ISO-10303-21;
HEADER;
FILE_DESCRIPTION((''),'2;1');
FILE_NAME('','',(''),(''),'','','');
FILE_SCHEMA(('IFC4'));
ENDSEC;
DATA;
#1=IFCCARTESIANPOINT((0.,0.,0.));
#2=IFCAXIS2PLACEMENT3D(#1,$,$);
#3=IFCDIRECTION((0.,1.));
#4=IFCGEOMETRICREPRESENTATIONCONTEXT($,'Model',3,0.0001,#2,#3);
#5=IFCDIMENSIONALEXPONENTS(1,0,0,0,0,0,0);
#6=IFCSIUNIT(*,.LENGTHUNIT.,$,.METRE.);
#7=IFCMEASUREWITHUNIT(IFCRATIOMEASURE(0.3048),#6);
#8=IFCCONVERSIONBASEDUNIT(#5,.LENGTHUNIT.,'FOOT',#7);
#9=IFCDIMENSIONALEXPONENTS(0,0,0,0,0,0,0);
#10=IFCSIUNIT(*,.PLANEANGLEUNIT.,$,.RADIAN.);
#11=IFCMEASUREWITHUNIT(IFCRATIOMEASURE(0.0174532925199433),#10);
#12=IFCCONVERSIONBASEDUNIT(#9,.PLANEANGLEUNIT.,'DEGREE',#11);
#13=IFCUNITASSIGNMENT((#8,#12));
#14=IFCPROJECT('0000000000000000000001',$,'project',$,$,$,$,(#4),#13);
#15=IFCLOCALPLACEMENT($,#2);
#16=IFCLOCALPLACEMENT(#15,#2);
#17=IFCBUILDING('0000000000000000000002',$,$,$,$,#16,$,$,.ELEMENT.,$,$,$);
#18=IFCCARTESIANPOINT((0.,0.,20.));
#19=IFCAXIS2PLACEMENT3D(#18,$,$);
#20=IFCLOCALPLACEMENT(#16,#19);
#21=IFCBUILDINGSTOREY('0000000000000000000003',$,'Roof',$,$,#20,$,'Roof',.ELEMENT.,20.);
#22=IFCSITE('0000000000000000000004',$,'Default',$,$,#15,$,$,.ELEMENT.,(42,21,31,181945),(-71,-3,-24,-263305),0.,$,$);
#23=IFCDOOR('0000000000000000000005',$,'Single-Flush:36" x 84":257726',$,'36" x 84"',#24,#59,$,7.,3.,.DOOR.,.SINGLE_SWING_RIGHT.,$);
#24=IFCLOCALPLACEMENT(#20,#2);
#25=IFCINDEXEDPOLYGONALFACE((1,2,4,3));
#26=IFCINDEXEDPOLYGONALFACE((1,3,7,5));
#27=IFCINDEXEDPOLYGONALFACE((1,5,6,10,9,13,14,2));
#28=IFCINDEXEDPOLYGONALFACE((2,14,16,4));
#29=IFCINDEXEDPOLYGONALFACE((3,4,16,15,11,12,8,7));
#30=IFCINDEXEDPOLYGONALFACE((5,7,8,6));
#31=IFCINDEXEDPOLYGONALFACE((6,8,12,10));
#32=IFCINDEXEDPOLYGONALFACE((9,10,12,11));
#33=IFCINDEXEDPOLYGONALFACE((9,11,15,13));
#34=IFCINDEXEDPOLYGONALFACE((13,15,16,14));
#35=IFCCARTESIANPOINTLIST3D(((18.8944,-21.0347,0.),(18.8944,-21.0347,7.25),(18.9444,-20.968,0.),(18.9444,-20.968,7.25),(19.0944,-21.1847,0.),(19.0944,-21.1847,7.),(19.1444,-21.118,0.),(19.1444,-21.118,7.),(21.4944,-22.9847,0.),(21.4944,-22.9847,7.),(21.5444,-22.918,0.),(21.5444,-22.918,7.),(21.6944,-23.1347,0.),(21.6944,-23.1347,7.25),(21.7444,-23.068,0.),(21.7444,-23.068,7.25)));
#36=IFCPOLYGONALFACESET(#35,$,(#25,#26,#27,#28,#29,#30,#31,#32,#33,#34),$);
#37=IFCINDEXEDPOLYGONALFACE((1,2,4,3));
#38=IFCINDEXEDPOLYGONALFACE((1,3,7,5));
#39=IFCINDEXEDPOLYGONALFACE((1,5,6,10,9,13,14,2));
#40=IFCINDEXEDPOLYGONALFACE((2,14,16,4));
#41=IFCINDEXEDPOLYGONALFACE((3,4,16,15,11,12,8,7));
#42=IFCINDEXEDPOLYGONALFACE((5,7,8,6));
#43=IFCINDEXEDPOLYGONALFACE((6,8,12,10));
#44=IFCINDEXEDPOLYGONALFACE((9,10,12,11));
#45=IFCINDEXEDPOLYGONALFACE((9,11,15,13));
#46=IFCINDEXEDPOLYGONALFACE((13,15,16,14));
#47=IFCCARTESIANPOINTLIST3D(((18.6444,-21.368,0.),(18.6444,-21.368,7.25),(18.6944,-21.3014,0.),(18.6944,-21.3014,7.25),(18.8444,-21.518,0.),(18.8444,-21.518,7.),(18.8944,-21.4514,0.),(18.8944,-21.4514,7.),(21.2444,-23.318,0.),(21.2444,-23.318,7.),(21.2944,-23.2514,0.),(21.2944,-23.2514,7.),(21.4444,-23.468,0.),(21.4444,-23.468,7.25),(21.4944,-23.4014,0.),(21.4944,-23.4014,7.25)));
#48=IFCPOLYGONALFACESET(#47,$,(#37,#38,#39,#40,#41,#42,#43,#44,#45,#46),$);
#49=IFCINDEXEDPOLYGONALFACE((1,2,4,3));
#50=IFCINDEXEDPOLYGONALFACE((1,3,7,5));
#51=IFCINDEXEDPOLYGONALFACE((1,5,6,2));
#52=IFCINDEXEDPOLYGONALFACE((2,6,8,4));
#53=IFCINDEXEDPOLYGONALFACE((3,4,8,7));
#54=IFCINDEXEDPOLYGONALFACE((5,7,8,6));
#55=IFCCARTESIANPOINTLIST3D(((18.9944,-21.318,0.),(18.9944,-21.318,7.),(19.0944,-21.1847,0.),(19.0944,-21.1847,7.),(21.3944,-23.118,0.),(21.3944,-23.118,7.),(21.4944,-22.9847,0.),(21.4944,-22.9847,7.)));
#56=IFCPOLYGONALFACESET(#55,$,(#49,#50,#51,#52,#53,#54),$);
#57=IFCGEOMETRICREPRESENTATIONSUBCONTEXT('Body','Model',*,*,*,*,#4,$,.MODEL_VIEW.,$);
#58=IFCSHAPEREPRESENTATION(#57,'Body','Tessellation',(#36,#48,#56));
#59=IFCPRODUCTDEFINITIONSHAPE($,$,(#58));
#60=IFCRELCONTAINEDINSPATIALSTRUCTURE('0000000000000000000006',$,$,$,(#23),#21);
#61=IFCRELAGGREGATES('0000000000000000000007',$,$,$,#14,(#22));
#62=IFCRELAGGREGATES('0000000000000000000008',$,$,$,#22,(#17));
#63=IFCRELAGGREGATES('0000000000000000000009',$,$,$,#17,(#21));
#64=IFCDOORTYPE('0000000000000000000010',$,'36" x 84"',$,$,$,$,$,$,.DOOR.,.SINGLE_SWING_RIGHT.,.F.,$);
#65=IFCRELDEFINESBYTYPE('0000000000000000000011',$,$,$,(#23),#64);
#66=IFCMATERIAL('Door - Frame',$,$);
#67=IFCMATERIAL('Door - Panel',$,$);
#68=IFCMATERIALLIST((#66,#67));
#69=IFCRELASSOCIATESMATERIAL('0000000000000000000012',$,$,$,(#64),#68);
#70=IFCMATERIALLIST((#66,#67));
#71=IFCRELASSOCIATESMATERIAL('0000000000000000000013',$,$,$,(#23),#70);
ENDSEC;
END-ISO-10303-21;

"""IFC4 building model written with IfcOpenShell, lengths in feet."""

from ifc_helpers import new_model, entity, si_unit, converted_unit, direction, frame, frame_2d, origin, place, context, subcontext, project, spatial, polyline, rectangle, outline, extrude, source, transform, mapped, material, material_list, type_object, type_shapes, element, save


model = new_model("IFC4")

# Units and contexts
model_context = context("Model", 3, precision=0.0001, world=origin(), true_north=direction((0.0, 1.0)))
body_context = subcontext(model_context, "Body", "Model", "MODEL_VIEW")
ifc_project = project(units=[converted_unit("LENGTHUNIT", "FOOT", entity("IfcRatioMeasure", 0.3048), si_unit("LENGTHUNIT", "METRE"), dimensions=[1, 0, 0, 0, 0, 0, 0]), converted_unit("PLANEANGLEUNIT", "DEGREE", entity("IfcRatioMeasure", 0.0174532925199433), si_unit("PLANEANGLEUNIT", "RADIAN"), dimensions=[0, 0, 0, 0, 0, 0, 0])], contexts=[model_context])

# Site, building, storey
site_placement = place(None, origin())
site = spatial("IfcSite", under=ifc_project, at=site_placement, Name="Default", CompositionType="ELEMENT", RefLatitude=(42, 21, 31, 181945), RefLongitude=(-71, -3, -24, -263305), RefElevation=0.0)
building_placement = place(site_placement, origin())
building = spatial("IfcBuilding", under=site, at=building_placement, CompositionType="ELEMENT")
storey_placement = place(building_placement, frame((0.0, 0.0, 20.0)))
storey = spatial("IfcBuildingStorey", under=building, at=storey_placement, Name="Roof", LongName="Roof", CompositionType="ELEMENT", Elevation=20.0)

# Door
ifc_material_1 = material(Name="Door - Frame")
ifc_material_2 = material(Name="Door - Panel")
ifc_material_list_1 = material_list([ifc_material_1, ifc_material_2])
ifc_material_list_2 = material_list([ifc_material_1, ifc_material_2])
door_type = type_object("IfcDoorType", Name="36\" x 84\"", OperationType="SINGLE_SWING_RIGHT", ParameterTakesPrecedence=False, PredefinedType="DOOR", material=ifc_material_list_2)
shared_shape = source(origin(), body_context, "Body", "SweptSolid", [
    extrude(outline(polyline([(-1.75, -3.6875), (1.75, -3.6875), (1.75, 3.5625), (1.5, 3.5625), (1.5, -3.4375), (-1.5, -3.4375), (-1.5, 3.5625), (-1.75, 3.5625), (-1.75, -3.6875)])), frame((1.5, 0.3333, 3.5625), z_axis=(0.0, 1.0, 0.0), x_axis=(1.0, 0.0, 0.0)), (0.0, 0.0, 1.0), 0.0833),
    extrude(outline(polyline([(-3.6875, -1.75), (3.5625, -1.75), (3.5625, -1.5), (-3.4375, -1.5), (-3.4375, 1.5), (3.5625, 1.5), (3.5625, 1.75), (-3.6875, 1.75), (-3.6875, -1.75)])), frame((1.5, -0.0833, 3.5625), z_axis=(0.0, 1.0, 0.0), x_axis=(0.0, 0.0, -1.0)), (0.0, 0.0, 1.0), 0.0833),
    extrude(rectangle(XDim=0.1667, YDim=3.0, at=frame_2d((0.0, 0.0), x_axis=(1.0, 0.0))), frame((1.5, 0.25, 0.0), z_axis=(0.0, 0.0, 1.0), x_axis=(0.0, 1.0, 0.0)), (0.0, 0.0, 1.0), 7.0),
])
type_shapes(door_type, [shared_shape])
placement_1 = place(storey_placement, frame((47.9059, -43.0017, 0.0), z_axis=(0.0, 0.0, 1.0), x_axis=(-0.8, 0.6, 0.0)))
placement_2 = place(placement_1, frame((36.1394, 0.1667, 0.0)))
door_placement = place(placement_2, frame((0.0, 0.0, 0.0), z_axis=(0.0, 0.0, 1.0), x_axis=(-1.0, 0.0, 0.0)))
element("IfcDoor", 1, at=door_placement, inside=storey, type_object=door_type, material=ifc_material_list_1, Name="Single-Flush:36\" x 84\":257726", ObjectType="36\" x 84\"", OperationType="SINGLE_SWING_RIGHT", OverallHeight=7.0, OverallWidth=3.0, PredefinedType="DOOR", context=body_context, shape_type="MappedRepresentation", body=[
    mapped(shared_shape, transform((0.0, 0.0, 0.0), scale=1.0)),
])

save(model, "model.ifc")
